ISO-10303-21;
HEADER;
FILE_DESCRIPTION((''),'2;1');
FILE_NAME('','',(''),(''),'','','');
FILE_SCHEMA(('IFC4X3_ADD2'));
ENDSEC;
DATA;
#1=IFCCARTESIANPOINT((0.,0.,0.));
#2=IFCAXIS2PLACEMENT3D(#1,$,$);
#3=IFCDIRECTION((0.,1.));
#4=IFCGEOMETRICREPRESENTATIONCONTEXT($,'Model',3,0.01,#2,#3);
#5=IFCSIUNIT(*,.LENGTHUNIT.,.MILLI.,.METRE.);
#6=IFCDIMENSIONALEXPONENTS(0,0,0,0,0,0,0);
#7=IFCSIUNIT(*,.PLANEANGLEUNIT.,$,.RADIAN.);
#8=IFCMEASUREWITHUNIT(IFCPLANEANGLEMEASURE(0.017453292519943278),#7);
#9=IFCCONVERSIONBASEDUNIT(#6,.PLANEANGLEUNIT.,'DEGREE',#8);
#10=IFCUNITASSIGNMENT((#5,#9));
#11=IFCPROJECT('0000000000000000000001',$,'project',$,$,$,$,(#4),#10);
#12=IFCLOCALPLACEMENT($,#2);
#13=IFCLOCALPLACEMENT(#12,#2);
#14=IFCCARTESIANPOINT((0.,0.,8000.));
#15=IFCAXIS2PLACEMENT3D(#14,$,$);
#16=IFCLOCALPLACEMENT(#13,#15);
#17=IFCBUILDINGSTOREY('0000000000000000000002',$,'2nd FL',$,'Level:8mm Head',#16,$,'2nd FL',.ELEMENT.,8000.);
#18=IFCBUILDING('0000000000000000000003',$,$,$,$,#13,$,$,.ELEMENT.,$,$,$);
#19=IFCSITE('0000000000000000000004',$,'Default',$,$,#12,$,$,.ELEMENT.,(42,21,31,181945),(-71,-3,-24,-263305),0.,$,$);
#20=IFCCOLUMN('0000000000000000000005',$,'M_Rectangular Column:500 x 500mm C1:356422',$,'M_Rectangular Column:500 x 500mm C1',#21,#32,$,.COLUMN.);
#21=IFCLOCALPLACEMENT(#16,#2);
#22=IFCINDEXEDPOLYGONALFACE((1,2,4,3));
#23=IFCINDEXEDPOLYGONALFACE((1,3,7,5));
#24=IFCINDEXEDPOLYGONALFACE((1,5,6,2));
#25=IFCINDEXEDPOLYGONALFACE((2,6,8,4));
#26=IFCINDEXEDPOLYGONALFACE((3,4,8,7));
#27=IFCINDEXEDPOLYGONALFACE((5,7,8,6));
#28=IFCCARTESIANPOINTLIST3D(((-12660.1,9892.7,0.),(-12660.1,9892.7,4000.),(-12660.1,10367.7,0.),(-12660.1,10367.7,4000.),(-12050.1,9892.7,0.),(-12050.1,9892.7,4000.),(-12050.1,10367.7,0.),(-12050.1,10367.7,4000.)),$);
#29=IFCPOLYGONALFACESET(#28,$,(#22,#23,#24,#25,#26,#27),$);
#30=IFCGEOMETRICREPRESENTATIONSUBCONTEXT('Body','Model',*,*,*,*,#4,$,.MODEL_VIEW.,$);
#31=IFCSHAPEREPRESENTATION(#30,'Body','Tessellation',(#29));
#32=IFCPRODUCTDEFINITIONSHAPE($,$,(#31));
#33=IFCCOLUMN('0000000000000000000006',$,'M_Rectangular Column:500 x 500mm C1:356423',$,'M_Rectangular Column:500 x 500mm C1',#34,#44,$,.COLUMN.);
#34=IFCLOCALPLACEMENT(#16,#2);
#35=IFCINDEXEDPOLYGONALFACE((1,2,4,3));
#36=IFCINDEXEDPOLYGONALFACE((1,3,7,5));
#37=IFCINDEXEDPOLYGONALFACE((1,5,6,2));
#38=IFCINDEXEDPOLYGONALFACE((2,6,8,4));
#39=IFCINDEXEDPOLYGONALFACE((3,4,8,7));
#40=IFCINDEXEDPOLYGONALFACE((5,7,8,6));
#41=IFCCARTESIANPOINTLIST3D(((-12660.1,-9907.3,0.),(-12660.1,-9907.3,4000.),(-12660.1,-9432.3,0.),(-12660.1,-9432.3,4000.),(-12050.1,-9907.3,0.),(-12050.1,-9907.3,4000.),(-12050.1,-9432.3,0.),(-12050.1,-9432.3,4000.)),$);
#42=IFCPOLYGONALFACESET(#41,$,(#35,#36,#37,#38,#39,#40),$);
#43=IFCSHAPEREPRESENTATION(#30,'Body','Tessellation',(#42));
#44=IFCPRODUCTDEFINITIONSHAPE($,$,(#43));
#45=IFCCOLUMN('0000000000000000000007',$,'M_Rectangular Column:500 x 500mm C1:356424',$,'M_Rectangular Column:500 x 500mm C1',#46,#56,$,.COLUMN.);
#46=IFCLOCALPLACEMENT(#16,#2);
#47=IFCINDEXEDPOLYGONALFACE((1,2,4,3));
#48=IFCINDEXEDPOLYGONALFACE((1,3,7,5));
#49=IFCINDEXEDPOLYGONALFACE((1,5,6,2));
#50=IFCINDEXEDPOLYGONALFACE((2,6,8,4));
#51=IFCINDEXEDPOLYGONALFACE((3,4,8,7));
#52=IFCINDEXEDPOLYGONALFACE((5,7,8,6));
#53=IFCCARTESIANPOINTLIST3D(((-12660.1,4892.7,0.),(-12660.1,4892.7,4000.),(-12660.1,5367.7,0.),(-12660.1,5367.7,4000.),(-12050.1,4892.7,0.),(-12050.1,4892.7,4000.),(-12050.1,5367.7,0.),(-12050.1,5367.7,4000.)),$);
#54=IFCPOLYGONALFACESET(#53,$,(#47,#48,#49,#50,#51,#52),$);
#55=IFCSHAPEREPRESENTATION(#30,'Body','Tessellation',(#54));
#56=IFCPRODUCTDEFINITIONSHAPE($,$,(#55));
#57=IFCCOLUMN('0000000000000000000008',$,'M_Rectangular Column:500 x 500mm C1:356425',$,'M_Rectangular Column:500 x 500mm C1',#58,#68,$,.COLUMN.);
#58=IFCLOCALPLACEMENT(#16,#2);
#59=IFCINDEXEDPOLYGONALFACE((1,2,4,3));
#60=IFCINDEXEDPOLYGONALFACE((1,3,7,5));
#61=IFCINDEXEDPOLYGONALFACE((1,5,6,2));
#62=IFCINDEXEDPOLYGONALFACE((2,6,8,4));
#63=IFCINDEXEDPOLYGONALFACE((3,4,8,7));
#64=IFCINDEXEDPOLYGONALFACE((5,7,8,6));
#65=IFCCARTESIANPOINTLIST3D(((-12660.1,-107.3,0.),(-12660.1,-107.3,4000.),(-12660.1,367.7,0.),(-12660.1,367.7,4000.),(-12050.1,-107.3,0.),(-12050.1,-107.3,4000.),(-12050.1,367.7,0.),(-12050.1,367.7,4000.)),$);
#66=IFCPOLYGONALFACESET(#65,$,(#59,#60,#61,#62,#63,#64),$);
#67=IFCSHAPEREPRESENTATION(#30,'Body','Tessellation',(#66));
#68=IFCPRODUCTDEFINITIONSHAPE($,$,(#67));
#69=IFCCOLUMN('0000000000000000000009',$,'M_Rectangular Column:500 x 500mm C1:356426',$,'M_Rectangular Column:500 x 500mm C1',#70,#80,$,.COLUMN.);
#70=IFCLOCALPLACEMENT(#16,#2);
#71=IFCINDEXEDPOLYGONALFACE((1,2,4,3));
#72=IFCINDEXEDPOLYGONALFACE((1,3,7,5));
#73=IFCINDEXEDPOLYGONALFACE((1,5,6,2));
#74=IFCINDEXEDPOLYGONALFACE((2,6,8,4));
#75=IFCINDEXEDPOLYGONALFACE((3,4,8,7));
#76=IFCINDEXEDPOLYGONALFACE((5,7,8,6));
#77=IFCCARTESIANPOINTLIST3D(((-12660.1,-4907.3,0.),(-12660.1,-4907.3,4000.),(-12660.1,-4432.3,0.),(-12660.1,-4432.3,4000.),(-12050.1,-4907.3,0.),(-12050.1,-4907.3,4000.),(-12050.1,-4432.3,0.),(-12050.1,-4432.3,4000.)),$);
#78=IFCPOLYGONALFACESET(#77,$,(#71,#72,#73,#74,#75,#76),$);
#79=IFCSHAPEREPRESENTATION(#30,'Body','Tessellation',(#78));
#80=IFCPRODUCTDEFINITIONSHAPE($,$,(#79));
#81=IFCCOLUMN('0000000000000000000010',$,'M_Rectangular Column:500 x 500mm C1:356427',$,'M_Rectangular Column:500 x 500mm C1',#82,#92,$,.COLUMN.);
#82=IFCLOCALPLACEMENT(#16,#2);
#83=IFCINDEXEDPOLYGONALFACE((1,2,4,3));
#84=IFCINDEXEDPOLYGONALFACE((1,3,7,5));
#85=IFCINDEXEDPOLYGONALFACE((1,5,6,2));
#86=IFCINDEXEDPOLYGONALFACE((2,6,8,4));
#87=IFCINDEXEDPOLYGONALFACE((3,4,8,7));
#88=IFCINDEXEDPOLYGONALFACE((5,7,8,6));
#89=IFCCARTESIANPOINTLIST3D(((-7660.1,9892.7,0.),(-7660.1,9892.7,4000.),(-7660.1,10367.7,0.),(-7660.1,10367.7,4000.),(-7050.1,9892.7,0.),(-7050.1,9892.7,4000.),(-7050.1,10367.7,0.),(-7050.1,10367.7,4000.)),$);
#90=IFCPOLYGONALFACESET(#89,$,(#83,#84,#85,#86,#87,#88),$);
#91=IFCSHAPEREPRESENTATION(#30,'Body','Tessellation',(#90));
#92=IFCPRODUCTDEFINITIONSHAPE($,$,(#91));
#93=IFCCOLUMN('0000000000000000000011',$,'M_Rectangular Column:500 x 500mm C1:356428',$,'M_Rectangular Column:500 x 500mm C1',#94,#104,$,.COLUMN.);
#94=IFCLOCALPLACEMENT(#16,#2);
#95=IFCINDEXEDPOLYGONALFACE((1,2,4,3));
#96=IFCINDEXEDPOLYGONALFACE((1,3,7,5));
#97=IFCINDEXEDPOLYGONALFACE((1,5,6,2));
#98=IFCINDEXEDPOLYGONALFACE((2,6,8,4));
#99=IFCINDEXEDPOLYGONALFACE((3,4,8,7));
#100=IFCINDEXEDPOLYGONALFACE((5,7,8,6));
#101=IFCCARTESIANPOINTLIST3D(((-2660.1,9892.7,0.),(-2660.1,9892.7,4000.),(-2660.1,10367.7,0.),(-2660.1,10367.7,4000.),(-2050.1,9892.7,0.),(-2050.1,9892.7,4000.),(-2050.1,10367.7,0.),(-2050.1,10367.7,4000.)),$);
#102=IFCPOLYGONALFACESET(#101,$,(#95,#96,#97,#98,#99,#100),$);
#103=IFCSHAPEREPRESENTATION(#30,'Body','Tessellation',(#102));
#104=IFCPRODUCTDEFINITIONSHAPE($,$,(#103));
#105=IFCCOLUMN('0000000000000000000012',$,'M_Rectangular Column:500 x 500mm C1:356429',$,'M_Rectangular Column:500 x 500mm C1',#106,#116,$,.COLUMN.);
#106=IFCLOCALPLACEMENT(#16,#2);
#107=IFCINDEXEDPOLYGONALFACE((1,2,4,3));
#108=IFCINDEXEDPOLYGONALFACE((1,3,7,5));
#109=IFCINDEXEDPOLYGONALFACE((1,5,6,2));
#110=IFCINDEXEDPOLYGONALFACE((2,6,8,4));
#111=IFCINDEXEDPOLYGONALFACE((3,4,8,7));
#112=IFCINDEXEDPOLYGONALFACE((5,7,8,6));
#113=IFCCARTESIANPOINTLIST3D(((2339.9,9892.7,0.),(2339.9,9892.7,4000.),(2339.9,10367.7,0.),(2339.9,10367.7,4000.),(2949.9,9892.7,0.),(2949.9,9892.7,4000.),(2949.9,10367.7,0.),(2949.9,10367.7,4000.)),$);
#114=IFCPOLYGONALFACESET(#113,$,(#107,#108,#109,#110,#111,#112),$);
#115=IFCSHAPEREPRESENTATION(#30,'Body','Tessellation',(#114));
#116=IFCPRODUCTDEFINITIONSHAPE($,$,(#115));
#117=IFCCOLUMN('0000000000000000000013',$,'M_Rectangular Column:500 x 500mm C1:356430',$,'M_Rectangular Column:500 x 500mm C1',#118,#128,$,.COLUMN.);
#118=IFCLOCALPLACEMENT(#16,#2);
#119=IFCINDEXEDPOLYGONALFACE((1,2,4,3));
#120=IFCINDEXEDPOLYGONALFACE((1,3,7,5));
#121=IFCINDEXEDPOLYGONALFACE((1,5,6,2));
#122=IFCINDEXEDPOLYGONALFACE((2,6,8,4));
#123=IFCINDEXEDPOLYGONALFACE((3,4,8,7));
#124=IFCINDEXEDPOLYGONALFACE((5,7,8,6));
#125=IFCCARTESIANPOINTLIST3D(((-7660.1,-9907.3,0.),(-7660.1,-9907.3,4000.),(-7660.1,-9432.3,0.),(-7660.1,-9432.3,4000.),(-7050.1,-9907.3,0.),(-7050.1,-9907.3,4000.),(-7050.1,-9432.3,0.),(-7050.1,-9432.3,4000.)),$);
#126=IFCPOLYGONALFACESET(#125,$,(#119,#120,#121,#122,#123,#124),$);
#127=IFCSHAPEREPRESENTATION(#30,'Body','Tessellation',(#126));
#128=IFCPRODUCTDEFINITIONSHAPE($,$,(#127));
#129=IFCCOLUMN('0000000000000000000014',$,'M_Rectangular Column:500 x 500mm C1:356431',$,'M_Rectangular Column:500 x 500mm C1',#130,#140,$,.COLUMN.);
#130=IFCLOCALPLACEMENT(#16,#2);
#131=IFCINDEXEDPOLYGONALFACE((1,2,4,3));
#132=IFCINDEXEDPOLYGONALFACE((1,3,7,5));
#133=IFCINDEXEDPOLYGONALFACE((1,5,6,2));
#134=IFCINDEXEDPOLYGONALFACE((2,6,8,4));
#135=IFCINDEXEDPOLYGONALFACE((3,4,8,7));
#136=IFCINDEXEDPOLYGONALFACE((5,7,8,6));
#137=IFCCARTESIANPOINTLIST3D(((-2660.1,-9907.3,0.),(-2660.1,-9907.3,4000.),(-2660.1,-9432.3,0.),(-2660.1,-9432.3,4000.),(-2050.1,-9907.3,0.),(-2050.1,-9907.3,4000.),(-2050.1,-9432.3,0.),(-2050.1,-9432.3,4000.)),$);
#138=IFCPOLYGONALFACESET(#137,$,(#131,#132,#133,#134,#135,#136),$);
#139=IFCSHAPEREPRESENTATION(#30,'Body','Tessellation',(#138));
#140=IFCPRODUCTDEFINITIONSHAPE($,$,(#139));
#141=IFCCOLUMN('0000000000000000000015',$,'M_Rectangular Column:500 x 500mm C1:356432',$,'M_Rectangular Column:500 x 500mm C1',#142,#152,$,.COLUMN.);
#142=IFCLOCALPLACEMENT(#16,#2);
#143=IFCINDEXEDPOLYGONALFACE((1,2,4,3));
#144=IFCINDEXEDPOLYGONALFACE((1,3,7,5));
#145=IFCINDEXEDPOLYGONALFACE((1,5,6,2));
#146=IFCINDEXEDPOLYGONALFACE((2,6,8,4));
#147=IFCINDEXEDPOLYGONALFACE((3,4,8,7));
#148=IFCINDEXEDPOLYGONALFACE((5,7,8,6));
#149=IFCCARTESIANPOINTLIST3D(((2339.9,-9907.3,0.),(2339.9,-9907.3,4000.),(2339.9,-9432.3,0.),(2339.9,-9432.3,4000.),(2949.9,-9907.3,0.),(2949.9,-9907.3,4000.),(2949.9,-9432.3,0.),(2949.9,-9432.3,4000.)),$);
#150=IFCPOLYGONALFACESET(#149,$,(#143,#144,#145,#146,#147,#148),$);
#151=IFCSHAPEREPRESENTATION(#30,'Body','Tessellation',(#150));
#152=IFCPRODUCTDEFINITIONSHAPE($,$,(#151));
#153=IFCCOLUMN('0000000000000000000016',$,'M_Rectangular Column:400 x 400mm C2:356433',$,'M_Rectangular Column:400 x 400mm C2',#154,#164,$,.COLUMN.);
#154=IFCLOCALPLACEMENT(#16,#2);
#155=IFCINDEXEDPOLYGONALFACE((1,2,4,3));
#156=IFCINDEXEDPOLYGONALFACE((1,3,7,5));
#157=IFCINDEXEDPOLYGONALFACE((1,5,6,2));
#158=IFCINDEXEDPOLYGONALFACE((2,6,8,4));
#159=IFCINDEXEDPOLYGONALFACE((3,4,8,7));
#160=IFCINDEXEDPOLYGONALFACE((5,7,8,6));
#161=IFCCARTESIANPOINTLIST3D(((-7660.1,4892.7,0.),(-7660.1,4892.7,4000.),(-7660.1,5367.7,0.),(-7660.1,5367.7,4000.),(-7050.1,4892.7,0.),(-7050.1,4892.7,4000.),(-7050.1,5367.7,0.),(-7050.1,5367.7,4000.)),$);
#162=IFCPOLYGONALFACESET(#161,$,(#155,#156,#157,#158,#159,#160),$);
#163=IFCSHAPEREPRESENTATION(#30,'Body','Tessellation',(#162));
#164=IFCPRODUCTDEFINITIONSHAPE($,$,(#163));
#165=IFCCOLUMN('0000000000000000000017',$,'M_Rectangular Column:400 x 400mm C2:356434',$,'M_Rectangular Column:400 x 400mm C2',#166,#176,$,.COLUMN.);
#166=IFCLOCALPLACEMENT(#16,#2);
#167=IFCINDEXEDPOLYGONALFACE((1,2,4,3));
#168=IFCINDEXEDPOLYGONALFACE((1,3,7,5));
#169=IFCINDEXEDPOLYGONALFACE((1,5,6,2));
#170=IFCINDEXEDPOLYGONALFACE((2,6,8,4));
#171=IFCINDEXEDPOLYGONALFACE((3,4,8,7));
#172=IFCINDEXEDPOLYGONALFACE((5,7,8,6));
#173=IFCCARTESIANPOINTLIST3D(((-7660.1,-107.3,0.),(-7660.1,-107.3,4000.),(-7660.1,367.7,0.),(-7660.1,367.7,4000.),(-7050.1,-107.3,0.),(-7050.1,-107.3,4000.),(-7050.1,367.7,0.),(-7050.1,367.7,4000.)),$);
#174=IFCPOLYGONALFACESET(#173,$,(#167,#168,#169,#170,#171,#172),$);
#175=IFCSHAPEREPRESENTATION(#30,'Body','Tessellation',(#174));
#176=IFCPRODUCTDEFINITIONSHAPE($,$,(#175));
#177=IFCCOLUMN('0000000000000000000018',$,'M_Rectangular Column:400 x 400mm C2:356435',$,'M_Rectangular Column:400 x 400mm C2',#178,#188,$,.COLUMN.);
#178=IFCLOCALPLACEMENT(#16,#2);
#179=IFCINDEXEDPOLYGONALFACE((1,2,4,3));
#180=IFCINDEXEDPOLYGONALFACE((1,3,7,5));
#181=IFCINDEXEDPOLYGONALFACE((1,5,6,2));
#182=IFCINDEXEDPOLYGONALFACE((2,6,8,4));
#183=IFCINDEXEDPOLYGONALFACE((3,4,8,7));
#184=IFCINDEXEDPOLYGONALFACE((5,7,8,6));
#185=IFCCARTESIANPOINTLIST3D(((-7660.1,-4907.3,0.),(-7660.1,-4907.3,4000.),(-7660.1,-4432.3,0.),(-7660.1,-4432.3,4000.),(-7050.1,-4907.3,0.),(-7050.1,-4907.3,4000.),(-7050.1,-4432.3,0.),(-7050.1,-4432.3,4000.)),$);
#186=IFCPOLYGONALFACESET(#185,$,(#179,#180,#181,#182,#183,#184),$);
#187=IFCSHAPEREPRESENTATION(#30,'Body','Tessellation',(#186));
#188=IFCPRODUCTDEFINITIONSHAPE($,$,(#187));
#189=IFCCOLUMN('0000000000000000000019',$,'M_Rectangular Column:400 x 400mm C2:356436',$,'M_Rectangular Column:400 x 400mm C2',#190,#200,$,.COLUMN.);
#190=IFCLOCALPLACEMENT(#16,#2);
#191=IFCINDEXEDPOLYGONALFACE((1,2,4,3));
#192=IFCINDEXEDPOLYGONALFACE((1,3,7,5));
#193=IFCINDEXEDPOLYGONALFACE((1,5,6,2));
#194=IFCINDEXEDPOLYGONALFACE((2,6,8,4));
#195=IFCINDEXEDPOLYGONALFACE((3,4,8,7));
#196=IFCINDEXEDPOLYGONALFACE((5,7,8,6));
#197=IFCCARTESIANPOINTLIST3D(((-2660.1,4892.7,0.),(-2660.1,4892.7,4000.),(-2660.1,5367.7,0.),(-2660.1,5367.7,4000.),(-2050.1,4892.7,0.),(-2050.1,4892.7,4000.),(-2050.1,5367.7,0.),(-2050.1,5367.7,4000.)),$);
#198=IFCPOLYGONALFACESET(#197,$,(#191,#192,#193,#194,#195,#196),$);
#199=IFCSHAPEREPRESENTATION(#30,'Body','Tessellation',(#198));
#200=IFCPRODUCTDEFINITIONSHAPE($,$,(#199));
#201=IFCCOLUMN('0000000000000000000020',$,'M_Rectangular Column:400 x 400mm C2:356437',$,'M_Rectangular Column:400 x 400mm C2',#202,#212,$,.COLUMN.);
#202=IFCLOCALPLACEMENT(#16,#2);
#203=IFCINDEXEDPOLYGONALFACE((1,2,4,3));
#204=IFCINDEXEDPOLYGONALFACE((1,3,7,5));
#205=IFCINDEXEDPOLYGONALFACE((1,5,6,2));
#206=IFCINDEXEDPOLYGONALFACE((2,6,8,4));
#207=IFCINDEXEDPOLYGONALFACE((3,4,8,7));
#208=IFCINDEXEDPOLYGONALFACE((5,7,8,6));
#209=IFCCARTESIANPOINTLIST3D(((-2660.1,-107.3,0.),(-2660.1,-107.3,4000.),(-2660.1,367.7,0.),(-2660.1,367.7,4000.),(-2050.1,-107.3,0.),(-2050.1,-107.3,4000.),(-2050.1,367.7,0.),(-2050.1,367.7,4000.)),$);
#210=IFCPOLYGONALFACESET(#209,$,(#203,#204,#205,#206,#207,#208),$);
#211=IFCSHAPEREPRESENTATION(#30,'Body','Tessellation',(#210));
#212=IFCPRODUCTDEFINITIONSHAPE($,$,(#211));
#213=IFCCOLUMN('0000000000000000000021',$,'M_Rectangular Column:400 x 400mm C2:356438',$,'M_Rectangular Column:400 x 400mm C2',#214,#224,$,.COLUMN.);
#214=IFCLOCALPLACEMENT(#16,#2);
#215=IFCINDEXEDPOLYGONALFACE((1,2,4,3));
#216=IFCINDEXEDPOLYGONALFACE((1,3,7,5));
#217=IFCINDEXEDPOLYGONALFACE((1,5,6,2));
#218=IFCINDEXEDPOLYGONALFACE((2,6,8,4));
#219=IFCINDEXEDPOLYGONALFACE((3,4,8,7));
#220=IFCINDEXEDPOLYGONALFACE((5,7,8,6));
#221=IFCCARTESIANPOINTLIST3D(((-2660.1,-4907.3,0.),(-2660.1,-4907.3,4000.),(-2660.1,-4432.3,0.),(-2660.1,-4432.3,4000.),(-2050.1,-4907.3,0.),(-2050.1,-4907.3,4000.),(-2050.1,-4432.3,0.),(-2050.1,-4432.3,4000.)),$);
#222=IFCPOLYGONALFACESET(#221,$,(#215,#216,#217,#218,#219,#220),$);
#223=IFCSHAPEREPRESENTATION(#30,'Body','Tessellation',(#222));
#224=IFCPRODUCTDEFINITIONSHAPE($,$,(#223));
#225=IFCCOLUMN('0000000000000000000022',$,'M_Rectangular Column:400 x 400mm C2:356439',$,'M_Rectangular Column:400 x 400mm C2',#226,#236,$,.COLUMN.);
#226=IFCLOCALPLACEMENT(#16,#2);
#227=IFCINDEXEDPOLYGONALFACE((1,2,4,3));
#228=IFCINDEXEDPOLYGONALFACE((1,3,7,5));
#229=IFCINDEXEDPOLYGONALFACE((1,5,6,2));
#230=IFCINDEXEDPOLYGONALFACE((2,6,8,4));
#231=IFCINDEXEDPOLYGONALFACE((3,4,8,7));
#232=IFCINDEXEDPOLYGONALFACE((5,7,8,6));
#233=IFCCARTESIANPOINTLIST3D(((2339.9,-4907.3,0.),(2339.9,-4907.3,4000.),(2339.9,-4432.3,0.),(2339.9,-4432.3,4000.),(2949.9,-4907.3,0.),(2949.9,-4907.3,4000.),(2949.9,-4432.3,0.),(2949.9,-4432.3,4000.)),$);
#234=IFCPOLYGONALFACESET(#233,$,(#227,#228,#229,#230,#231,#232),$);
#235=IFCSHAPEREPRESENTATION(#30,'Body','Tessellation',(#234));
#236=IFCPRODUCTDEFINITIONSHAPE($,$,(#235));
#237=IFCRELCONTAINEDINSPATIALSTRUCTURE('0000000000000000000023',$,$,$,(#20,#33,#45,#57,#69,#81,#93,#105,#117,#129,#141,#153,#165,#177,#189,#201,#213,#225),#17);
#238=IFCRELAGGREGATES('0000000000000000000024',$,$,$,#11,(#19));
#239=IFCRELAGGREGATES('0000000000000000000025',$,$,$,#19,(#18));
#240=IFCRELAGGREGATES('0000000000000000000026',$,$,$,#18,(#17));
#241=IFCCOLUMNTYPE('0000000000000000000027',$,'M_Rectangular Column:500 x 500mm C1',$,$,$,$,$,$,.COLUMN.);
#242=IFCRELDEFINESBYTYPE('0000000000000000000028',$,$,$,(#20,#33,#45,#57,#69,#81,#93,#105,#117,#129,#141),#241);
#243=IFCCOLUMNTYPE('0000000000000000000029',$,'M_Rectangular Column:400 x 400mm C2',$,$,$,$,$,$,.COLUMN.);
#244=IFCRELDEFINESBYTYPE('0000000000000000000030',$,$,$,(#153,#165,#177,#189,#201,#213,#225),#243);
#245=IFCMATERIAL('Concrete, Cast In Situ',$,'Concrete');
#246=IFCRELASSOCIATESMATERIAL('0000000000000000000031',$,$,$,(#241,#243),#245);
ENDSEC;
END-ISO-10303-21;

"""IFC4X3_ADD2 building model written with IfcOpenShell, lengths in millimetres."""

from ifc_helpers import new_model, entity, si_unit, converted_unit, direction, frame, frame_2d, origin, origin_2d_with_axis, place, context, subcontext, project, spatial, rectangle, extrude, source, transform, mapped, material, material_profile, profile_set, type_object, type_shapes, element, save


model = new_model("IFC4X3_ADD2")

# Units and contexts
model_context = context("Model", 3, precision=0.01, world=origin(), true_north=direction((0.0, 1.0)))
body_context = subcontext(model_context, "Body", "Model", "MODEL_VIEW")
ifc_project = project(units=[si_unit("LENGTHUNIT", "METRE", prefix="MILLI"), converted_unit("PLANEANGLEUNIT", "DEGREE", entity("IfcPlaneAngleMeasure", 0.017453292519943278), si_unit("PLANEANGLEUNIT", "RADIAN"), dimensions=[0, 0, 0, 0, 0, 0, 0])], contexts=[model_context])

# Site, building, storey
site_placement = place(None, origin())
site = spatial("IfcSite", under=ifc_project, at=site_placement, Name="Default", CompositionType="ELEMENT", RefLatitude=(42, 21, 31, 181945), RefLongitude=(-71, -3, -24, -263305), RefElevation=0.0)
building_placement = place(site_placement, origin())
building = spatial("IfcBuilding", under=site, at=building_placement, CompositionType="ELEMENT")
storey_placement = place(building_placement, frame((0.0, 0.0, 8000.0)))
storey = spatial("IfcBuildingStorey", under=building, at=storey_placement, Name="2nd FL", ObjectType="Level:8mm Head", LongName="2nd FL", CompositionType="ELEMENT", Elevation=8000.0)

# Columns
ifc_material_1 = material(Name="Concrete, Cast In Situ", Category="Concrete")
ifc_material_profile_1 = material_profile(ifc_material_1, rectangle(XDim=610.0, YDim=475.0, at=frame_2d((0.0, 0.0), x_axis=(1.0, 0.0))), Name="500 x 500mm C1")
ifc_profile_set_1 = profile_set([ifc_material_profile_1], Name="500 x 500mm C1")
column_type_1 = type_object("IfcColumnType", Name="M_Rectangular Column:500 x 500mm C1", PredefinedType="COLUMN", material=ifc_profile_set_1)
shared_shape_1 = source(origin(), body_context, "Body", "SweptSolid", [
    extrude(rectangle(XDim=610.0, YDim=475.0, at=origin_2d_with_axis()), frame((0.0, 0.0, 8000.0), z_axis=(0.0, 0.0, 1.0), x_axis=(-1.0, 0.0, 0.0)), (0.0, 0.0, 1.0), 4000.0),
])
type_shapes(column_type_1, [shared_shape_1])
for number, where, name in (
    (1, (-12355.1, 10130.2, -8000.0), "M_Rectangular Column:500 x 500mm C1:356422"),
    (2, (-12355.1, -9669.8, -8000.0), "M_Rectangular Column:500 x 500mm C1:356423"),
    (3, (-12355.1, 5130.2, -8000.0), "M_Rectangular Column:500 x 500mm C1:356424"),
    (4, (-12355.1, 130.2, -8000.0), "M_Rectangular Column:500 x 500mm C1:356425"),
    (5, (-12355.1, -4669.8, -8000.0), "M_Rectangular Column:500 x 500mm C1:356426"),
    (6, (-7355.1, 10130.2, -8000.0), "M_Rectangular Column:500 x 500mm C1:356427"),
    (7, (-2355.1, 10130.2, -8000.0), "M_Rectangular Column:500 x 500mm C1:356428"),
    (8, (2644.9, 10130.2, -8000.0), "M_Rectangular Column:500 x 500mm C1:356429"),
    (9, (-7355.1, -9669.8, -8000.0), "M_Rectangular Column:500 x 500mm C1:356430"),
    (10, (-2355.1, -9669.8, -8000.0), "M_Rectangular Column:500 x 500mm C1:356431"),
    (11, (2644.9, -9669.8, -8000.0), "M_Rectangular Column:500 x 500mm C1:356432"),
):
    element("IfcColumn", number, at=place(storey_placement, frame(where)), inside=storey, type_object=column_type_1, Name=name, ObjectType="M_Rectangular Column:500 x 500mm C1", PredefinedType="COLUMN", context=body_context, shape_type="MappedRepresentation", body=[
        mapped(shared_shape_1, transform((0.0, 0.0, 0.0), scale=1.0)),
    ])
ifc_material_profile_2 = material_profile(ifc_material_1, rectangle(XDim=610.0, YDim=475.0, at=origin_2d_with_axis()), Name="400 x 400mm C2")
ifc_profile_set_2 = profile_set([ifc_material_profile_2], Name="400 x 400mm C2")
column_type_2 = type_object("IfcColumnType", Name="M_Rectangular Column:400 x 400mm C2", PredefinedType="COLUMN", material=ifc_profile_set_2)
shared_shape_2 = source(origin(), body_context, "Body", "SweptSolid", [
    extrude(rectangle(XDim=610.0, YDim=475.0, at=origin_2d_with_axis()), frame((0.0, 0.0, 8000.0), z_axis=(0.0, 0.0, 1.0), x_axis=(-1.0, 0.0, 0.0)), (0.0, 0.0, 1.0), 4000.0),
])
type_shapes(column_type_2, [shared_shape_2])
for number, where, name in (
    (12, (-7355.1, 5130.2, -8000.0), "M_Rectangular Column:400 x 400mm C2:356433"),
    (13, (-7355.1, 130.2, -8000.0), "M_Rectangular Column:400 x 400mm C2:356434"),
    (14, (-7355.1, -4669.8, -8000.0), "M_Rectangular Column:400 x 400mm C2:356435"),
    (15, (-2355.1, 5130.2, -8000.0), "M_Rectangular Column:400 x 400mm C2:356436"),
    (16, (-2355.1, 130.2, -8000.0), "M_Rectangular Column:400 x 400mm C2:356437"),
    (17, (-2355.1, -4669.8, -8000.0), "M_Rectangular Column:400 x 400mm C2:356438"),
    (18, (2644.9, -4669.8, -8000.0), "M_Rectangular Column:400 x 400mm C2:356439"),
):
    element("IfcColumn", number, at=place(storey_placement, frame(where)), inside=storey, type_object=column_type_2, Name=name, ObjectType="M_Rectangular Column:400 x 400mm C2", PredefinedType="COLUMN", context=body_context, shape_type="MappedRepresentation", body=[
        mapped(shared_shape_2, transform((0.0, 0.0, 0.0), scale=1.0)),
    ])

save(model, "model.ifc")
